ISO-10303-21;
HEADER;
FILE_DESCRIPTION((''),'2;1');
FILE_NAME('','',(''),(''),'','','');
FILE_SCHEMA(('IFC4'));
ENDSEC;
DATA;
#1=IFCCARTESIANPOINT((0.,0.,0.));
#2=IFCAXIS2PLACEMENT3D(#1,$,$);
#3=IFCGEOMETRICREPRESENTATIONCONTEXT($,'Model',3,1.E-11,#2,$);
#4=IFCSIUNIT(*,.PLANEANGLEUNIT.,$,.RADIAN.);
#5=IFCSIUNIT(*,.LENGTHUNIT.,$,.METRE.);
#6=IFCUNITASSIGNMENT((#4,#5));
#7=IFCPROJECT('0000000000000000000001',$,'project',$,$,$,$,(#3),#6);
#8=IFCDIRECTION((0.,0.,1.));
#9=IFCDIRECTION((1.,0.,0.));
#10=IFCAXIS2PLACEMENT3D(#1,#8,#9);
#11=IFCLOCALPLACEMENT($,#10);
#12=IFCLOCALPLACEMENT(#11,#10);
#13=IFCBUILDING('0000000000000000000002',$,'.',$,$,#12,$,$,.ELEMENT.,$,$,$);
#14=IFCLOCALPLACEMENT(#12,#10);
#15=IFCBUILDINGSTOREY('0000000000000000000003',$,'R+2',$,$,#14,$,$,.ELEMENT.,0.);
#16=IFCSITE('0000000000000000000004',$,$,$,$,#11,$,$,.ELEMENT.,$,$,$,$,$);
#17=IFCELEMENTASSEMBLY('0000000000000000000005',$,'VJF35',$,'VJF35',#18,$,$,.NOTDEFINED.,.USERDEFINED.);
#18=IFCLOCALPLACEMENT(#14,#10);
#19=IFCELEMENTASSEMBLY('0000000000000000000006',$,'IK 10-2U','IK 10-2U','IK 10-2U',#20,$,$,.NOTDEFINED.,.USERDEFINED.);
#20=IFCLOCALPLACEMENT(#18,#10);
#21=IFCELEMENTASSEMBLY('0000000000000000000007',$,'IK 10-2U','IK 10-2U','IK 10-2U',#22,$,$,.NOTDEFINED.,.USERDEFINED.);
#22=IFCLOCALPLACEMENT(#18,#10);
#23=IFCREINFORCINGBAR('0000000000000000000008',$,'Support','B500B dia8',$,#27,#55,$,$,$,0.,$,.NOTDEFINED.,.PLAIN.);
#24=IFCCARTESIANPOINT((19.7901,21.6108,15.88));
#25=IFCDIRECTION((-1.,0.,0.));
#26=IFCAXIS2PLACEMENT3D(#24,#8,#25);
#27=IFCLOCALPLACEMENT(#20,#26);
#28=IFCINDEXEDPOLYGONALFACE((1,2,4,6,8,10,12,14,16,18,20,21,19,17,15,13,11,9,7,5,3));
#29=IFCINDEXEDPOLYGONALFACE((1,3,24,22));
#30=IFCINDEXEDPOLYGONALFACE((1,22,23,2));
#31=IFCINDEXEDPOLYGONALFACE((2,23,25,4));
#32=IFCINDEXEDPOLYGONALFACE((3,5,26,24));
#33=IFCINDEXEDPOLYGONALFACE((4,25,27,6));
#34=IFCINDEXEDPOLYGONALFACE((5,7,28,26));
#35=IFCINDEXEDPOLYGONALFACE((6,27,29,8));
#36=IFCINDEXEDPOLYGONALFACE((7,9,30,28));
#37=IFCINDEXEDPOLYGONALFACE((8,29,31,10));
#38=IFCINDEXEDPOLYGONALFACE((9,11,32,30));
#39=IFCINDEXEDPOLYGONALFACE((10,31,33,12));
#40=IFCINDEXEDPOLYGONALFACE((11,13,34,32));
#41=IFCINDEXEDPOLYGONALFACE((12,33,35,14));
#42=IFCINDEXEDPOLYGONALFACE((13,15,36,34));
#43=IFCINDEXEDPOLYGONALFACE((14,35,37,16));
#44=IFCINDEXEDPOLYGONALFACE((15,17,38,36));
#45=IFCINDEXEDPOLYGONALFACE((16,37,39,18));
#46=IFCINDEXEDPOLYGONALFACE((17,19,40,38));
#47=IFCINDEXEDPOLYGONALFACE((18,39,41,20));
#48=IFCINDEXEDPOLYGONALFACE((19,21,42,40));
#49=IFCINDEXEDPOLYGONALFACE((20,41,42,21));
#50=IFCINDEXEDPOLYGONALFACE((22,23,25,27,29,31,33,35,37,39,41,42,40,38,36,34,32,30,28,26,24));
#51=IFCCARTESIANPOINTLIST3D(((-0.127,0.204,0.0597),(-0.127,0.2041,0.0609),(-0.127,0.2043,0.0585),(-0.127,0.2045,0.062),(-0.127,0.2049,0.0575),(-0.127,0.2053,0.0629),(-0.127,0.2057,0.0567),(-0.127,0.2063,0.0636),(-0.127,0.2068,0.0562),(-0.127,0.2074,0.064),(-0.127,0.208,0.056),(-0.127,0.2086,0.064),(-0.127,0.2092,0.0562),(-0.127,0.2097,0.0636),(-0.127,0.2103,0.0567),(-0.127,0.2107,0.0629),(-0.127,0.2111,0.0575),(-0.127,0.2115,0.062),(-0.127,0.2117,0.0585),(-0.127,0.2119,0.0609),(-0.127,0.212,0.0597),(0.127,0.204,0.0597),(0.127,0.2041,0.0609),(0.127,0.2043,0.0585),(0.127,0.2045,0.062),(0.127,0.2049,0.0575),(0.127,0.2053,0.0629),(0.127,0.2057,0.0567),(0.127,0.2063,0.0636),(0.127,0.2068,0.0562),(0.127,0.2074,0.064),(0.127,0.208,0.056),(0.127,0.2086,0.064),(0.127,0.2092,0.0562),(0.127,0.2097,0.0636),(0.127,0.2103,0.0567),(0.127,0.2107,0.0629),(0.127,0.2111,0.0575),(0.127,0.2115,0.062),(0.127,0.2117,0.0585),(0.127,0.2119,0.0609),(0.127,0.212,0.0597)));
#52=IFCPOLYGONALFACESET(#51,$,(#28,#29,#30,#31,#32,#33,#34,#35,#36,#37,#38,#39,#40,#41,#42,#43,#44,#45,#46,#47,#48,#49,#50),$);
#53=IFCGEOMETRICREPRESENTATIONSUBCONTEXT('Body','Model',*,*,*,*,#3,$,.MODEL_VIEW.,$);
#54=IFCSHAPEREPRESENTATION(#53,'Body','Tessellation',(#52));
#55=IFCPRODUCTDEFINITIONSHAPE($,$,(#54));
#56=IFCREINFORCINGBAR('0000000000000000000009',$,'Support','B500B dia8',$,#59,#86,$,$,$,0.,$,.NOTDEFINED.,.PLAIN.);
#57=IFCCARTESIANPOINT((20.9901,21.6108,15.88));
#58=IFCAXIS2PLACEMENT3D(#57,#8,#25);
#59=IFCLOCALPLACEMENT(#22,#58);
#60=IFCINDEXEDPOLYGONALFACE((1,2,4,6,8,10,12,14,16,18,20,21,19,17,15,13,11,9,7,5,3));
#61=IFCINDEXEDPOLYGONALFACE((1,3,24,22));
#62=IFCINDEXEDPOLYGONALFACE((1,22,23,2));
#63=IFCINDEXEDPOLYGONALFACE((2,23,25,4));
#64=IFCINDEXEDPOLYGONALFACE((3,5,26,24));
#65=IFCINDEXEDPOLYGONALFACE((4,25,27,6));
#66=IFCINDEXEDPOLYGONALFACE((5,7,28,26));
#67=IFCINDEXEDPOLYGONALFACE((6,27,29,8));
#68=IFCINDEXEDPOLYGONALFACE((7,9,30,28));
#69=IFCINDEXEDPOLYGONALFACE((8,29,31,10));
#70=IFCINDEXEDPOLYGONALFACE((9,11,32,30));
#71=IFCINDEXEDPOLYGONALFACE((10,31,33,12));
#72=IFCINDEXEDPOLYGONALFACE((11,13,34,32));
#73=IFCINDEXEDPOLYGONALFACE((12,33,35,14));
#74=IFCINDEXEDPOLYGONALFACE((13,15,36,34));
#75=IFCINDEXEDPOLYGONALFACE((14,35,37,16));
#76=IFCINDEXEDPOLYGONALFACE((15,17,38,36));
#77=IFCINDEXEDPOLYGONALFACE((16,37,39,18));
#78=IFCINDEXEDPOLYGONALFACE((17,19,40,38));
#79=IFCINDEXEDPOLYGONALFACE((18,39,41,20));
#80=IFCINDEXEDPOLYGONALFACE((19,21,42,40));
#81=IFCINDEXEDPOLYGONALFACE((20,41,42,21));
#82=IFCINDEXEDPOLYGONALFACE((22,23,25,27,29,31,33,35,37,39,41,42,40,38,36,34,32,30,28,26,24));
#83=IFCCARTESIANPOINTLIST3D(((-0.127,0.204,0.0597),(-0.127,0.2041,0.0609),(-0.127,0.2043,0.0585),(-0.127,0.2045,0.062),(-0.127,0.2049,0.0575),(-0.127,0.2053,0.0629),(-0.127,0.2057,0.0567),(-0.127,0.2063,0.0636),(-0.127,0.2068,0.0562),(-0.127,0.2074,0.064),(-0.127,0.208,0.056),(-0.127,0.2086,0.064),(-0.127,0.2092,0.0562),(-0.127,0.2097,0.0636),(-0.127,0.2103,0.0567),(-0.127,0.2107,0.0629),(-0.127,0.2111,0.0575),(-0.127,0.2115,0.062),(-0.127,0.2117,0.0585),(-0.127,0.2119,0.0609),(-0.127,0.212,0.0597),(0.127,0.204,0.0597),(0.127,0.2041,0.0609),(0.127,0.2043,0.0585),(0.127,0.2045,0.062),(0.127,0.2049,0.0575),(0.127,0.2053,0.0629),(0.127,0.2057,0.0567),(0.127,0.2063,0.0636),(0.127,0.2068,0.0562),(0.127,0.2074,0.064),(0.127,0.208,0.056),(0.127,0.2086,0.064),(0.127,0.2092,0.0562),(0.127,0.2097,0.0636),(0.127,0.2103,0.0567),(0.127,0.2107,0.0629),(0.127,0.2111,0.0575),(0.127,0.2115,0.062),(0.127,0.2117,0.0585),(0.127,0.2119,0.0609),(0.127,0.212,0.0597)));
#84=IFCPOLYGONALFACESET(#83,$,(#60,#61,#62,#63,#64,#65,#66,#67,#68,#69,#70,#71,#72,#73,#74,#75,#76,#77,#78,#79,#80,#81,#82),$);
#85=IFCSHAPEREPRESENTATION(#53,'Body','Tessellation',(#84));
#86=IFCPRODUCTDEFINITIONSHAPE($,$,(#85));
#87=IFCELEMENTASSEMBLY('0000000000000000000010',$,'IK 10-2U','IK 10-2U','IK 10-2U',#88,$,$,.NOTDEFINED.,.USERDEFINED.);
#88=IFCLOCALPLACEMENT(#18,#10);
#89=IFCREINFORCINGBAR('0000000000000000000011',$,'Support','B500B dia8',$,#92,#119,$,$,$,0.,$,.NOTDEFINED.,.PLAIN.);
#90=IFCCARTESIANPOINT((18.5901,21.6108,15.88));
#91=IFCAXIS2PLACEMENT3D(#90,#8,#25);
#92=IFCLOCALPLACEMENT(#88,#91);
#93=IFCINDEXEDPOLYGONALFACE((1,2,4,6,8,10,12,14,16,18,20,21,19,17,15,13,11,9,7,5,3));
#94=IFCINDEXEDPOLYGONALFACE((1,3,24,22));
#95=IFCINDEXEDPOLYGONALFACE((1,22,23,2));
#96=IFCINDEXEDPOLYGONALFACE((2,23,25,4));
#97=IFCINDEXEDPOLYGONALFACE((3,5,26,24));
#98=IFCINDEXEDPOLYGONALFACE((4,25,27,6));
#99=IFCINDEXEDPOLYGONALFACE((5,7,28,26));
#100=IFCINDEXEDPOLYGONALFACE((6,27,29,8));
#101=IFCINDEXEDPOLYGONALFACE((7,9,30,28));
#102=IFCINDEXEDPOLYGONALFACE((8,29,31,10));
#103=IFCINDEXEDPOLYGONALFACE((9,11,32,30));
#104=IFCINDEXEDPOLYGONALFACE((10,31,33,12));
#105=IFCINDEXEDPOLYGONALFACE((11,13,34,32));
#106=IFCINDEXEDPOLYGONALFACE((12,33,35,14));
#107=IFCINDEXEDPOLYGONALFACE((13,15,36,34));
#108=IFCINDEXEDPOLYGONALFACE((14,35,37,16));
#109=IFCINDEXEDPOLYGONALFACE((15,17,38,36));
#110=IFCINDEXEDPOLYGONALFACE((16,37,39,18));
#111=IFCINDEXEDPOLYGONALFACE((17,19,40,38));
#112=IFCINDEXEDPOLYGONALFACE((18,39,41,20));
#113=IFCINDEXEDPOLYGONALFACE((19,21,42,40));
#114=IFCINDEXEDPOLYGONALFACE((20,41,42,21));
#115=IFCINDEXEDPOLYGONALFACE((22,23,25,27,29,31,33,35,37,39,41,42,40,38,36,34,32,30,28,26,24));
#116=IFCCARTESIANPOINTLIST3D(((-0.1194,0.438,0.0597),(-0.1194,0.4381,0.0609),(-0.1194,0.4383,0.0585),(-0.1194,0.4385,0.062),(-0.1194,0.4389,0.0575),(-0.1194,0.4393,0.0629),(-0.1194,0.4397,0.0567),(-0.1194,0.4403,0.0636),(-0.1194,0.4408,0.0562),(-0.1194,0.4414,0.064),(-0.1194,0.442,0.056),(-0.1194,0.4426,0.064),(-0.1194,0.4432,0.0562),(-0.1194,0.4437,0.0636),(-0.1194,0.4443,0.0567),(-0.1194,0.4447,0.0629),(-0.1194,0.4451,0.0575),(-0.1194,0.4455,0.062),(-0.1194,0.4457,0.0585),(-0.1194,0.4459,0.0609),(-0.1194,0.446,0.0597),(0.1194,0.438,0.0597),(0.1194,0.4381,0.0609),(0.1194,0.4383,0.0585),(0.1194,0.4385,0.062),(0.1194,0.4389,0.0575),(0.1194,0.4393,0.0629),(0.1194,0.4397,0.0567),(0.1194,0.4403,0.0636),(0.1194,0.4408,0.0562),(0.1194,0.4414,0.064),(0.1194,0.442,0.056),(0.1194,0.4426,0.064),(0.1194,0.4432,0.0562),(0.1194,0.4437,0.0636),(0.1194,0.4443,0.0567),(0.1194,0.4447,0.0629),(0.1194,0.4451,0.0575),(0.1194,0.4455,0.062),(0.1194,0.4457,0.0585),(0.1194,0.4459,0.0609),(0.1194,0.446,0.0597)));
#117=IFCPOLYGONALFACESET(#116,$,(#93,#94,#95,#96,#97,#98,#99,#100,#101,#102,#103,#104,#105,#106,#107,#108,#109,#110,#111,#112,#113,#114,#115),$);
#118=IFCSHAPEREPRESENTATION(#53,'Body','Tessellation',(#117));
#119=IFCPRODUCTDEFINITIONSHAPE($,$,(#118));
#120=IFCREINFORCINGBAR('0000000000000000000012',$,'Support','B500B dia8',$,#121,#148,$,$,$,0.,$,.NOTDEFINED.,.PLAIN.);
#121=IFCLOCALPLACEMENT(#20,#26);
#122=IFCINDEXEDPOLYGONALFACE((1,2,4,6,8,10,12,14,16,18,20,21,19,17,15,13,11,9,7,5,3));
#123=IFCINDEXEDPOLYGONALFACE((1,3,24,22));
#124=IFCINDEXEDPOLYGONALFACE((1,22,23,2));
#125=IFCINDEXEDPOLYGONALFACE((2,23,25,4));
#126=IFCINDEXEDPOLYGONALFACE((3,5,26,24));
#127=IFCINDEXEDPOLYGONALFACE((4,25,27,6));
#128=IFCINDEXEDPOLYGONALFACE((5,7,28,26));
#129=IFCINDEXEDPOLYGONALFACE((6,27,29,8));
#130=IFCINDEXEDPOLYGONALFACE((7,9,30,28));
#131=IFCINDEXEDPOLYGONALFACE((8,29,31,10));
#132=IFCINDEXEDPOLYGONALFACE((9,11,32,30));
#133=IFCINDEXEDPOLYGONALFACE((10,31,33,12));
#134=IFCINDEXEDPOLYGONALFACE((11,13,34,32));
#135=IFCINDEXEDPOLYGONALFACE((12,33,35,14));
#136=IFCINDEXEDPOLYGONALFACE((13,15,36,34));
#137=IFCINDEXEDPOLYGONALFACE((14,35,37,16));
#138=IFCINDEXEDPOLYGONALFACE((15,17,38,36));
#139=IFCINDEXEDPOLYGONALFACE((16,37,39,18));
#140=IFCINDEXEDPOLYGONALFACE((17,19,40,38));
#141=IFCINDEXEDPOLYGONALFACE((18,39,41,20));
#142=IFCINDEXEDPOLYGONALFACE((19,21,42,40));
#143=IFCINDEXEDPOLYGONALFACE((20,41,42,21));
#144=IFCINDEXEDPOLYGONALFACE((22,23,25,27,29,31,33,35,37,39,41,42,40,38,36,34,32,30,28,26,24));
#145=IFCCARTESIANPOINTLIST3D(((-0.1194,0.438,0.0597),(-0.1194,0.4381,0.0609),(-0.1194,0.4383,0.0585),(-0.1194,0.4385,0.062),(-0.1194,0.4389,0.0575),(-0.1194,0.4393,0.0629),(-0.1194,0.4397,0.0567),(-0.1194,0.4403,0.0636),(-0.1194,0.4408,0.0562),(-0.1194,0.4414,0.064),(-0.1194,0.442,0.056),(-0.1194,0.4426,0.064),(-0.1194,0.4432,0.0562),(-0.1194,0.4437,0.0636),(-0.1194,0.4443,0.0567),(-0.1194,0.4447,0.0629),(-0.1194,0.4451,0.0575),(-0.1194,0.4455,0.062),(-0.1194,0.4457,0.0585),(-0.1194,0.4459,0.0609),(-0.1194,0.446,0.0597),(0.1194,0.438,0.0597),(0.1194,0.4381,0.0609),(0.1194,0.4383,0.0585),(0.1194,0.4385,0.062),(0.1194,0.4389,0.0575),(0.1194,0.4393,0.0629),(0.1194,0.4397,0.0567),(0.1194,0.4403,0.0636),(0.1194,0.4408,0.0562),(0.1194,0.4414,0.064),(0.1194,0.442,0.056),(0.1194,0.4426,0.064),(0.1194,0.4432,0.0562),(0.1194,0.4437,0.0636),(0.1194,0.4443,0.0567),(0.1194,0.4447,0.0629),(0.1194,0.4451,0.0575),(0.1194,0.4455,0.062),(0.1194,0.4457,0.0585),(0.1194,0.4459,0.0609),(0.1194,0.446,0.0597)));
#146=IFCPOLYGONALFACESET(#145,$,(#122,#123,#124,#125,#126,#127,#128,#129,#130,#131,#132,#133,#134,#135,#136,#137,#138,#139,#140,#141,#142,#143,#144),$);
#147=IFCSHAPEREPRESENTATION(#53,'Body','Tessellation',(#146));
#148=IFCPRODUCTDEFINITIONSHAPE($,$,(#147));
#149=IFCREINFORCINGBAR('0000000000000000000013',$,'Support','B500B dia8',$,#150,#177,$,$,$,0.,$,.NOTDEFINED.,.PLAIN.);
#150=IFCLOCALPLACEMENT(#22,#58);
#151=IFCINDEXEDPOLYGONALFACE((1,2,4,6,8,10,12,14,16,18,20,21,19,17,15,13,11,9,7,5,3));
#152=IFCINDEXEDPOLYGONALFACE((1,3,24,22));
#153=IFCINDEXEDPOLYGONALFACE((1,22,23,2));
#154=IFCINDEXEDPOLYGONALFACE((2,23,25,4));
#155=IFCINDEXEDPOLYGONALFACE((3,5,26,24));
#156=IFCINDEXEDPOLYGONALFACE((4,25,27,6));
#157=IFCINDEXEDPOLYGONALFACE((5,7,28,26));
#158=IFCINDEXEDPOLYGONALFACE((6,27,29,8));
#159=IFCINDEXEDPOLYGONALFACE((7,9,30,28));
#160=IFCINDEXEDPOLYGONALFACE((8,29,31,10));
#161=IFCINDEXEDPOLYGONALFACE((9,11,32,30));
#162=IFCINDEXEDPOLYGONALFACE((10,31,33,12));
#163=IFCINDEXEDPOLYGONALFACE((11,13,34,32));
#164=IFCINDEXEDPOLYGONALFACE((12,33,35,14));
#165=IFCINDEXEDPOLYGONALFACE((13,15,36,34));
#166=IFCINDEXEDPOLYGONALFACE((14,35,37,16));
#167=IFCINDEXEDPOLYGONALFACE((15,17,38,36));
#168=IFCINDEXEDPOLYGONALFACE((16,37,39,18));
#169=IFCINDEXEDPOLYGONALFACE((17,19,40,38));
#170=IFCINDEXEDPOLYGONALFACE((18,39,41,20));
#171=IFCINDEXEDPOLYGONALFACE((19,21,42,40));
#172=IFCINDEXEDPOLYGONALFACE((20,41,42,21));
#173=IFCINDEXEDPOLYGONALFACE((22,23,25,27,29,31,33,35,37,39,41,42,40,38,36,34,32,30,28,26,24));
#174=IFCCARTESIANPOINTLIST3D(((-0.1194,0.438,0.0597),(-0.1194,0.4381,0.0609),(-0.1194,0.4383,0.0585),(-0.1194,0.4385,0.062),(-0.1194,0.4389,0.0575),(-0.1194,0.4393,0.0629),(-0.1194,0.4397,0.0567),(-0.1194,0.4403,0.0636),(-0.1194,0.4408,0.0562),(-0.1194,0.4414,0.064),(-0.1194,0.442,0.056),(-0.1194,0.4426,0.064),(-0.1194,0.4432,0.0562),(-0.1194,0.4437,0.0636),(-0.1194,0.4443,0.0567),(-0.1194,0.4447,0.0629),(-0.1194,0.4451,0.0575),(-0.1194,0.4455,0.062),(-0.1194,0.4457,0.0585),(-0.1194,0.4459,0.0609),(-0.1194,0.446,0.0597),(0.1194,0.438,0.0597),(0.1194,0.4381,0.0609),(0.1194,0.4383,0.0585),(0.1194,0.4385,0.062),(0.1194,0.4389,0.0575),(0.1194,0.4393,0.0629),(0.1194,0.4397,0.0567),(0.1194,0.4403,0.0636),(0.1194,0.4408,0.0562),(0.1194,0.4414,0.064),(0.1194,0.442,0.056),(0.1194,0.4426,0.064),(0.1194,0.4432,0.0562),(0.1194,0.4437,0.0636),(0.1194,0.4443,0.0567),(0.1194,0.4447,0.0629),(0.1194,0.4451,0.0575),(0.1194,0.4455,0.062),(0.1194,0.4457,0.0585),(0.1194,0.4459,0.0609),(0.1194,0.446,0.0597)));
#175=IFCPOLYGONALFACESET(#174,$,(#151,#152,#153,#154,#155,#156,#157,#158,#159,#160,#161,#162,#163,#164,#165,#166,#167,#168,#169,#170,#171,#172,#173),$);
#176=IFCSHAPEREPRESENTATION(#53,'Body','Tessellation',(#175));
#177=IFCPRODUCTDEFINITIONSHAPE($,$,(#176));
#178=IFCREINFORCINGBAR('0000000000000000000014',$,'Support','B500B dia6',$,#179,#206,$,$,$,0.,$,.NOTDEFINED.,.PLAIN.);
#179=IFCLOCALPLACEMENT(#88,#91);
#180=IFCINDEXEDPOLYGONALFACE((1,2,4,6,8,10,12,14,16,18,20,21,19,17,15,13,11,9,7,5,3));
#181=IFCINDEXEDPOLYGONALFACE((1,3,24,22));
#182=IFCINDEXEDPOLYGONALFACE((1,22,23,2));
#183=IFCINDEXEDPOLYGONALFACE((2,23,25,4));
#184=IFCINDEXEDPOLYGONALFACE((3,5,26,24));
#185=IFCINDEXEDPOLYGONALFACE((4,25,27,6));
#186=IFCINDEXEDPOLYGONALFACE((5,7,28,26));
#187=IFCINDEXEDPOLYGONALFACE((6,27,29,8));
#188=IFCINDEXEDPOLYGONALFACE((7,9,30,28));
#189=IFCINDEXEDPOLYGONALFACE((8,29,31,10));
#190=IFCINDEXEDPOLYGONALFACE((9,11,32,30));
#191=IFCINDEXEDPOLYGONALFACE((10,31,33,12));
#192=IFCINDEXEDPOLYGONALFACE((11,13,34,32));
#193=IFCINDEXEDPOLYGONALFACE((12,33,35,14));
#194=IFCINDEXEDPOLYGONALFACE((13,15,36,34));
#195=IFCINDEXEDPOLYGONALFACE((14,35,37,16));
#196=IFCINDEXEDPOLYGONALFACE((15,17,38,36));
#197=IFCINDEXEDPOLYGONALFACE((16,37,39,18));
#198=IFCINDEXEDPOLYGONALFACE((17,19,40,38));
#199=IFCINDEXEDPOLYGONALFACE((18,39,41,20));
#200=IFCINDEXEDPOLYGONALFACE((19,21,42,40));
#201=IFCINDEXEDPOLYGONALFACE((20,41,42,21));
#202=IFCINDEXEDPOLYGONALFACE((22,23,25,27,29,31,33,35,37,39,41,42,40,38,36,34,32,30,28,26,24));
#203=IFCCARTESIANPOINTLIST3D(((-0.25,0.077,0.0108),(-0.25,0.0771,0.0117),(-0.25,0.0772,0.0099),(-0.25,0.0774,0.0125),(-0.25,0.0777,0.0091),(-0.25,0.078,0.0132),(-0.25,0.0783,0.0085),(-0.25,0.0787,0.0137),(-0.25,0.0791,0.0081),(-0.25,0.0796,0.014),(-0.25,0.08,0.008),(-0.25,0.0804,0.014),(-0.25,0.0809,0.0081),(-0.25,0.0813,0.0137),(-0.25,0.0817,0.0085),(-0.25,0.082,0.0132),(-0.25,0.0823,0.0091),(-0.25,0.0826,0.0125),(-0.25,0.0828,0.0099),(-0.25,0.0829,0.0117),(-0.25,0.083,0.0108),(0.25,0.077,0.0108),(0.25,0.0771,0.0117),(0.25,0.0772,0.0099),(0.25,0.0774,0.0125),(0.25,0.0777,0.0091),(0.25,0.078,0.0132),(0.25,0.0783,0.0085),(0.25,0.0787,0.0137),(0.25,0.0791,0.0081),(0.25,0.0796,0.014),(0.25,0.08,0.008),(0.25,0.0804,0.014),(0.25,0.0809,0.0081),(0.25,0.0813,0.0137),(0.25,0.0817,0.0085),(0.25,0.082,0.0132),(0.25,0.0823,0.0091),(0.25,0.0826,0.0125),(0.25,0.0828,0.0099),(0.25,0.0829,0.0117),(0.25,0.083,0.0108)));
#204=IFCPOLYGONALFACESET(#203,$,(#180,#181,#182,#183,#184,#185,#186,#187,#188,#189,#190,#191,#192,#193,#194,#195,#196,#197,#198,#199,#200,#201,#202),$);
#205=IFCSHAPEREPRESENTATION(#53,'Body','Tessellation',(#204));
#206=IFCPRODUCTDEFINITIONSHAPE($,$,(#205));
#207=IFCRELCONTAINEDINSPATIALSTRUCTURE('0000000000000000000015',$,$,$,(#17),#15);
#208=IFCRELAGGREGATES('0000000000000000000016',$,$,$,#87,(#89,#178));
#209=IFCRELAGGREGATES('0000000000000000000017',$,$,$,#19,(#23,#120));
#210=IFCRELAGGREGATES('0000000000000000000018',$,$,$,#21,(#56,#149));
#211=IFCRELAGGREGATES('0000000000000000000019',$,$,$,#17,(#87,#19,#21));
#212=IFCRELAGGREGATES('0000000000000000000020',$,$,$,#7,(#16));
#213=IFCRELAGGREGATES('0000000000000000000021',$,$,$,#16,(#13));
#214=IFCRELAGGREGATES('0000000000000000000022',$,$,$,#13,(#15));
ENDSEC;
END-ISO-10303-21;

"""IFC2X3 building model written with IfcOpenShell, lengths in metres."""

from ifc_helpers import new_model, entity, si_unit, frame, origin, origin_with_axes, place, context, subcontext, project, spatial, source, transform, mapped, element, aggregate, save


model = new_model("IFC2X3")

# Units and contexts
model_context = context("Model", 3, precision=1e-11, world=origin())
body_context = subcontext(model_context, "Body", "Model", "MODEL_VIEW")
ifc_project = project(units=[si_unit("PLANEANGLEUNIT", "RADIAN"), si_unit("LENGTHUNIT", "METRE")], contexts=[model_context])

# Site, building, storey
site_placement = place(None, origin_with_axes())
site = spatial("IfcSite", under=ifc_project, at=site_placement, CompositionType="ELEMENT")
building_placement = place(site_placement, origin_with_axes())
building = spatial("IfcBuilding", under=site, at=building_placement, Name=".", CompositionType="ELEMENT")
storey_placement = place(building_placement, origin_with_axes())
storey = spatial("IfcBuildingStorey", under=building, at=storey_placement, Name="R+2", CompositionType="ELEMENT", Elevation=0.0)

# Element assemblies, reinforcing bars
assembly_1_placement = place(storey_placement, origin_with_axes())
assembly_1 = element("IfcElementAssembly", 1, at=assembly_1_placement, inside=storey, Name="VJF35", ObjectType="VJF35", AssemblyPlace="NOTDEFINED", PredefinedType="USERDEFINED")
assembly_2_placement = place(assembly_1_placement, origin_with_axes())
assembly_2 = element("IfcElementAssembly", 2, at=assembly_2_placement, Name="IK 10-2U", Description="IK 10-2U", ObjectType="IK 10-2U", AssemblyPlace="NOTDEFINED", PredefinedType="USERDEFINED")
assembly_3_placement = place(assembly_1_placement, origin_with_axes())
assembly_3 = element("IfcElementAssembly", 3, at=assembly_3_placement, Name="IK 10-2U", Description="IK 10-2U", ObjectType="IK 10-2U", AssemblyPlace="NOTDEFINED", PredefinedType="USERDEFINED")
shared_shape_1 = source(origin_with_axes(), body_context, "Body", "AdvancedSweptSolid", [
    entity("IfcSweptDiskSolid", entity("IfcPolyline", [entity("IfcCartesianPoint", [0.127, 0.208, 0.06]), entity("IfcCartesianPoint", [-0.127, 0.208, 0.06])]), 0.004, None, 0.0, 0.254),
])
reinforcing_bar_1_placement = place(assembly_2_placement, frame((19.7901, 21.6108, 15.88), z_axis=(0.0, 0.0, 1.0), x_axis=(-1.0, 0.0, 0.0)))
reinforcing_bar_1 = element("IfcReinforcingBar", 4, at=reinforcing_bar_1_placement, Name="Support", Description="B500B dia8", BarRole="NOTDEFINED", BarSurface="PLAIN", CrossSectionArea=0.0, context=body_context, shape_type="MappedRepresentation", body=[
    mapped(shared_shape_1, transform((0.0, 0.0, 0.0), scale=1.0)),
])
reinforcing_bar_2_placement = place(assembly_3_placement, frame((20.9901, 21.6108, 15.88), z_axis=(0.0, 0.0, 1.0), x_axis=(-1.0, 0.0, 0.0)))
reinforcing_bar_2 = element("IfcReinforcingBar", 5, at=reinforcing_bar_2_placement, Name="Support", Description="B500B dia8", BarRole="NOTDEFINED", BarSurface="PLAIN", CrossSectionArea=0.0, context=body_context, shape_type="MappedRepresentation", body=[
    mapped(shared_shape_1, transform((0.0, 0.0, 0.0), scale=1.0)),
])
assembly_4_placement = place(assembly_1_placement, origin_with_axes())
assembly_4 = element("IfcElementAssembly", 6, at=assembly_4_placement, Name="IK 10-2U", Description="IK 10-2U", ObjectType="IK 10-2U", AssemblyPlace="NOTDEFINED", PredefinedType="USERDEFINED")
shared_shape_2 = source(origin_with_axes(), body_context, "Body", "AdvancedSweptSolid", [
    entity("IfcSweptDiskSolid", entity("IfcPolyline", [entity("IfcCartesianPoint", [0.1194, 0.442, 0.06]), entity("IfcCartesianPoint", [-0.1194, 0.442, 0.06])]), 0.004, None, 0.0, 0.2388),
])
reinforcing_bar_3_placement = place(assembly_4_placement, frame((18.5901, 21.6108, 15.88), z_axis=(0.0, 0.0, 1.0), x_axis=(-1.0, 0.0, 0.0)))
reinforcing_bar_3 = element("IfcReinforcingBar", 7, at=reinforcing_bar_3_placement, Name="Support", Description="B500B dia8", BarRole="NOTDEFINED", BarSurface="PLAIN", CrossSectionArea=0.0, context=body_context, shape_type="MappedRepresentation", body=[
    mapped(shared_shape_2, transform((0.0, 0.0, 0.0), scale=1.0)),
])
reinforcing_bar_4_placement = place(assembly_2_placement, frame((19.7901, 21.6108, 15.88), z_axis=(0.0, 0.0, 1.0), x_axis=(-1.0, 0.0, 0.0)))
reinforcing_bar_4 = element("IfcReinforcingBar", 8, at=reinforcing_bar_4_placement, Name="Support", Description="B500B dia8", BarRole="NOTDEFINED", BarSurface="PLAIN", CrossSectionArea=0.0, context=body_context, shape_type="MappedRepresentation", body=[
    mapped(shared_shape_2, transform((0.0, 0.0, 0.0), scale=1.0)),
])
reinforcing_bar_5_placement = place(assembly_3_placement, frame((20.9901, 21.6108, 15.88), z_axis=(0.0, 0.0, 1.0), x_axis=(-1.0, 0.0, 0.0)))
reinforcing_bar_5 = element("IfcReinforcingBar", 9, at=reinforcing_bar_5_placement, Name="Support", Description="B500B dia8", BarRole="NOTDEFINED", BarSurface="PLAIN", CrossSectionArea=0.0, context=body_context, shape_type="MappedRepresentation", body=[
    mapped(shared_shape_2, transform((0.0, 0.0, 0.0), scale=1.0)),
])
shared_shape_3 = source(origin_with_axes(), body_context, "Body", "AdvancedSweptSolid", [
    entity("IfcSweptDiskSolid", entity("IfcPolyline", [entity("IfcCartesianPoint", [0.25, 0.08, 0.011]), entity("IfcCartesianPoint", [-0.25, 0.08, 0.011])]), 0.003, None, 0.0, 0.5),
])
reinforcing_bar_6_placement = place(assembly_4_placement, frame((18.5901, 21.6108, 15.88), z_axis=(0.0, 0.0, 1.0), x_axis=(-1.0, 0.0, 0.0)))
reinforcing_bar_6 = element("IfcReinforcingBar", 10, at=reinforcing_bar_6_placement, Name="Support", Description="B500B dia6", BarRole="NOTDEFINED", BarSurface="PLAIN", CrossSectionArea=0.0, context=body_context, shape_type="MappedRepresentation", body=[
    mapped(shared_shape_3, transform((0.0, 0.0, 0.0), scale=1.0)),
])
aggregate(assembly_4, [reinforcing_bar_3, reinforcing_bar_6])
aggregate(assembly_2, [reinforcing_bar_1, reinforcing_bar_4])
aggregate(assembly_3, [reinforcing_bar_2, reinforcing_bar_5])

aggregate(assembly_1, [assembly_4, assembly_2, assembly_3])

save(model, "model.ifc")
